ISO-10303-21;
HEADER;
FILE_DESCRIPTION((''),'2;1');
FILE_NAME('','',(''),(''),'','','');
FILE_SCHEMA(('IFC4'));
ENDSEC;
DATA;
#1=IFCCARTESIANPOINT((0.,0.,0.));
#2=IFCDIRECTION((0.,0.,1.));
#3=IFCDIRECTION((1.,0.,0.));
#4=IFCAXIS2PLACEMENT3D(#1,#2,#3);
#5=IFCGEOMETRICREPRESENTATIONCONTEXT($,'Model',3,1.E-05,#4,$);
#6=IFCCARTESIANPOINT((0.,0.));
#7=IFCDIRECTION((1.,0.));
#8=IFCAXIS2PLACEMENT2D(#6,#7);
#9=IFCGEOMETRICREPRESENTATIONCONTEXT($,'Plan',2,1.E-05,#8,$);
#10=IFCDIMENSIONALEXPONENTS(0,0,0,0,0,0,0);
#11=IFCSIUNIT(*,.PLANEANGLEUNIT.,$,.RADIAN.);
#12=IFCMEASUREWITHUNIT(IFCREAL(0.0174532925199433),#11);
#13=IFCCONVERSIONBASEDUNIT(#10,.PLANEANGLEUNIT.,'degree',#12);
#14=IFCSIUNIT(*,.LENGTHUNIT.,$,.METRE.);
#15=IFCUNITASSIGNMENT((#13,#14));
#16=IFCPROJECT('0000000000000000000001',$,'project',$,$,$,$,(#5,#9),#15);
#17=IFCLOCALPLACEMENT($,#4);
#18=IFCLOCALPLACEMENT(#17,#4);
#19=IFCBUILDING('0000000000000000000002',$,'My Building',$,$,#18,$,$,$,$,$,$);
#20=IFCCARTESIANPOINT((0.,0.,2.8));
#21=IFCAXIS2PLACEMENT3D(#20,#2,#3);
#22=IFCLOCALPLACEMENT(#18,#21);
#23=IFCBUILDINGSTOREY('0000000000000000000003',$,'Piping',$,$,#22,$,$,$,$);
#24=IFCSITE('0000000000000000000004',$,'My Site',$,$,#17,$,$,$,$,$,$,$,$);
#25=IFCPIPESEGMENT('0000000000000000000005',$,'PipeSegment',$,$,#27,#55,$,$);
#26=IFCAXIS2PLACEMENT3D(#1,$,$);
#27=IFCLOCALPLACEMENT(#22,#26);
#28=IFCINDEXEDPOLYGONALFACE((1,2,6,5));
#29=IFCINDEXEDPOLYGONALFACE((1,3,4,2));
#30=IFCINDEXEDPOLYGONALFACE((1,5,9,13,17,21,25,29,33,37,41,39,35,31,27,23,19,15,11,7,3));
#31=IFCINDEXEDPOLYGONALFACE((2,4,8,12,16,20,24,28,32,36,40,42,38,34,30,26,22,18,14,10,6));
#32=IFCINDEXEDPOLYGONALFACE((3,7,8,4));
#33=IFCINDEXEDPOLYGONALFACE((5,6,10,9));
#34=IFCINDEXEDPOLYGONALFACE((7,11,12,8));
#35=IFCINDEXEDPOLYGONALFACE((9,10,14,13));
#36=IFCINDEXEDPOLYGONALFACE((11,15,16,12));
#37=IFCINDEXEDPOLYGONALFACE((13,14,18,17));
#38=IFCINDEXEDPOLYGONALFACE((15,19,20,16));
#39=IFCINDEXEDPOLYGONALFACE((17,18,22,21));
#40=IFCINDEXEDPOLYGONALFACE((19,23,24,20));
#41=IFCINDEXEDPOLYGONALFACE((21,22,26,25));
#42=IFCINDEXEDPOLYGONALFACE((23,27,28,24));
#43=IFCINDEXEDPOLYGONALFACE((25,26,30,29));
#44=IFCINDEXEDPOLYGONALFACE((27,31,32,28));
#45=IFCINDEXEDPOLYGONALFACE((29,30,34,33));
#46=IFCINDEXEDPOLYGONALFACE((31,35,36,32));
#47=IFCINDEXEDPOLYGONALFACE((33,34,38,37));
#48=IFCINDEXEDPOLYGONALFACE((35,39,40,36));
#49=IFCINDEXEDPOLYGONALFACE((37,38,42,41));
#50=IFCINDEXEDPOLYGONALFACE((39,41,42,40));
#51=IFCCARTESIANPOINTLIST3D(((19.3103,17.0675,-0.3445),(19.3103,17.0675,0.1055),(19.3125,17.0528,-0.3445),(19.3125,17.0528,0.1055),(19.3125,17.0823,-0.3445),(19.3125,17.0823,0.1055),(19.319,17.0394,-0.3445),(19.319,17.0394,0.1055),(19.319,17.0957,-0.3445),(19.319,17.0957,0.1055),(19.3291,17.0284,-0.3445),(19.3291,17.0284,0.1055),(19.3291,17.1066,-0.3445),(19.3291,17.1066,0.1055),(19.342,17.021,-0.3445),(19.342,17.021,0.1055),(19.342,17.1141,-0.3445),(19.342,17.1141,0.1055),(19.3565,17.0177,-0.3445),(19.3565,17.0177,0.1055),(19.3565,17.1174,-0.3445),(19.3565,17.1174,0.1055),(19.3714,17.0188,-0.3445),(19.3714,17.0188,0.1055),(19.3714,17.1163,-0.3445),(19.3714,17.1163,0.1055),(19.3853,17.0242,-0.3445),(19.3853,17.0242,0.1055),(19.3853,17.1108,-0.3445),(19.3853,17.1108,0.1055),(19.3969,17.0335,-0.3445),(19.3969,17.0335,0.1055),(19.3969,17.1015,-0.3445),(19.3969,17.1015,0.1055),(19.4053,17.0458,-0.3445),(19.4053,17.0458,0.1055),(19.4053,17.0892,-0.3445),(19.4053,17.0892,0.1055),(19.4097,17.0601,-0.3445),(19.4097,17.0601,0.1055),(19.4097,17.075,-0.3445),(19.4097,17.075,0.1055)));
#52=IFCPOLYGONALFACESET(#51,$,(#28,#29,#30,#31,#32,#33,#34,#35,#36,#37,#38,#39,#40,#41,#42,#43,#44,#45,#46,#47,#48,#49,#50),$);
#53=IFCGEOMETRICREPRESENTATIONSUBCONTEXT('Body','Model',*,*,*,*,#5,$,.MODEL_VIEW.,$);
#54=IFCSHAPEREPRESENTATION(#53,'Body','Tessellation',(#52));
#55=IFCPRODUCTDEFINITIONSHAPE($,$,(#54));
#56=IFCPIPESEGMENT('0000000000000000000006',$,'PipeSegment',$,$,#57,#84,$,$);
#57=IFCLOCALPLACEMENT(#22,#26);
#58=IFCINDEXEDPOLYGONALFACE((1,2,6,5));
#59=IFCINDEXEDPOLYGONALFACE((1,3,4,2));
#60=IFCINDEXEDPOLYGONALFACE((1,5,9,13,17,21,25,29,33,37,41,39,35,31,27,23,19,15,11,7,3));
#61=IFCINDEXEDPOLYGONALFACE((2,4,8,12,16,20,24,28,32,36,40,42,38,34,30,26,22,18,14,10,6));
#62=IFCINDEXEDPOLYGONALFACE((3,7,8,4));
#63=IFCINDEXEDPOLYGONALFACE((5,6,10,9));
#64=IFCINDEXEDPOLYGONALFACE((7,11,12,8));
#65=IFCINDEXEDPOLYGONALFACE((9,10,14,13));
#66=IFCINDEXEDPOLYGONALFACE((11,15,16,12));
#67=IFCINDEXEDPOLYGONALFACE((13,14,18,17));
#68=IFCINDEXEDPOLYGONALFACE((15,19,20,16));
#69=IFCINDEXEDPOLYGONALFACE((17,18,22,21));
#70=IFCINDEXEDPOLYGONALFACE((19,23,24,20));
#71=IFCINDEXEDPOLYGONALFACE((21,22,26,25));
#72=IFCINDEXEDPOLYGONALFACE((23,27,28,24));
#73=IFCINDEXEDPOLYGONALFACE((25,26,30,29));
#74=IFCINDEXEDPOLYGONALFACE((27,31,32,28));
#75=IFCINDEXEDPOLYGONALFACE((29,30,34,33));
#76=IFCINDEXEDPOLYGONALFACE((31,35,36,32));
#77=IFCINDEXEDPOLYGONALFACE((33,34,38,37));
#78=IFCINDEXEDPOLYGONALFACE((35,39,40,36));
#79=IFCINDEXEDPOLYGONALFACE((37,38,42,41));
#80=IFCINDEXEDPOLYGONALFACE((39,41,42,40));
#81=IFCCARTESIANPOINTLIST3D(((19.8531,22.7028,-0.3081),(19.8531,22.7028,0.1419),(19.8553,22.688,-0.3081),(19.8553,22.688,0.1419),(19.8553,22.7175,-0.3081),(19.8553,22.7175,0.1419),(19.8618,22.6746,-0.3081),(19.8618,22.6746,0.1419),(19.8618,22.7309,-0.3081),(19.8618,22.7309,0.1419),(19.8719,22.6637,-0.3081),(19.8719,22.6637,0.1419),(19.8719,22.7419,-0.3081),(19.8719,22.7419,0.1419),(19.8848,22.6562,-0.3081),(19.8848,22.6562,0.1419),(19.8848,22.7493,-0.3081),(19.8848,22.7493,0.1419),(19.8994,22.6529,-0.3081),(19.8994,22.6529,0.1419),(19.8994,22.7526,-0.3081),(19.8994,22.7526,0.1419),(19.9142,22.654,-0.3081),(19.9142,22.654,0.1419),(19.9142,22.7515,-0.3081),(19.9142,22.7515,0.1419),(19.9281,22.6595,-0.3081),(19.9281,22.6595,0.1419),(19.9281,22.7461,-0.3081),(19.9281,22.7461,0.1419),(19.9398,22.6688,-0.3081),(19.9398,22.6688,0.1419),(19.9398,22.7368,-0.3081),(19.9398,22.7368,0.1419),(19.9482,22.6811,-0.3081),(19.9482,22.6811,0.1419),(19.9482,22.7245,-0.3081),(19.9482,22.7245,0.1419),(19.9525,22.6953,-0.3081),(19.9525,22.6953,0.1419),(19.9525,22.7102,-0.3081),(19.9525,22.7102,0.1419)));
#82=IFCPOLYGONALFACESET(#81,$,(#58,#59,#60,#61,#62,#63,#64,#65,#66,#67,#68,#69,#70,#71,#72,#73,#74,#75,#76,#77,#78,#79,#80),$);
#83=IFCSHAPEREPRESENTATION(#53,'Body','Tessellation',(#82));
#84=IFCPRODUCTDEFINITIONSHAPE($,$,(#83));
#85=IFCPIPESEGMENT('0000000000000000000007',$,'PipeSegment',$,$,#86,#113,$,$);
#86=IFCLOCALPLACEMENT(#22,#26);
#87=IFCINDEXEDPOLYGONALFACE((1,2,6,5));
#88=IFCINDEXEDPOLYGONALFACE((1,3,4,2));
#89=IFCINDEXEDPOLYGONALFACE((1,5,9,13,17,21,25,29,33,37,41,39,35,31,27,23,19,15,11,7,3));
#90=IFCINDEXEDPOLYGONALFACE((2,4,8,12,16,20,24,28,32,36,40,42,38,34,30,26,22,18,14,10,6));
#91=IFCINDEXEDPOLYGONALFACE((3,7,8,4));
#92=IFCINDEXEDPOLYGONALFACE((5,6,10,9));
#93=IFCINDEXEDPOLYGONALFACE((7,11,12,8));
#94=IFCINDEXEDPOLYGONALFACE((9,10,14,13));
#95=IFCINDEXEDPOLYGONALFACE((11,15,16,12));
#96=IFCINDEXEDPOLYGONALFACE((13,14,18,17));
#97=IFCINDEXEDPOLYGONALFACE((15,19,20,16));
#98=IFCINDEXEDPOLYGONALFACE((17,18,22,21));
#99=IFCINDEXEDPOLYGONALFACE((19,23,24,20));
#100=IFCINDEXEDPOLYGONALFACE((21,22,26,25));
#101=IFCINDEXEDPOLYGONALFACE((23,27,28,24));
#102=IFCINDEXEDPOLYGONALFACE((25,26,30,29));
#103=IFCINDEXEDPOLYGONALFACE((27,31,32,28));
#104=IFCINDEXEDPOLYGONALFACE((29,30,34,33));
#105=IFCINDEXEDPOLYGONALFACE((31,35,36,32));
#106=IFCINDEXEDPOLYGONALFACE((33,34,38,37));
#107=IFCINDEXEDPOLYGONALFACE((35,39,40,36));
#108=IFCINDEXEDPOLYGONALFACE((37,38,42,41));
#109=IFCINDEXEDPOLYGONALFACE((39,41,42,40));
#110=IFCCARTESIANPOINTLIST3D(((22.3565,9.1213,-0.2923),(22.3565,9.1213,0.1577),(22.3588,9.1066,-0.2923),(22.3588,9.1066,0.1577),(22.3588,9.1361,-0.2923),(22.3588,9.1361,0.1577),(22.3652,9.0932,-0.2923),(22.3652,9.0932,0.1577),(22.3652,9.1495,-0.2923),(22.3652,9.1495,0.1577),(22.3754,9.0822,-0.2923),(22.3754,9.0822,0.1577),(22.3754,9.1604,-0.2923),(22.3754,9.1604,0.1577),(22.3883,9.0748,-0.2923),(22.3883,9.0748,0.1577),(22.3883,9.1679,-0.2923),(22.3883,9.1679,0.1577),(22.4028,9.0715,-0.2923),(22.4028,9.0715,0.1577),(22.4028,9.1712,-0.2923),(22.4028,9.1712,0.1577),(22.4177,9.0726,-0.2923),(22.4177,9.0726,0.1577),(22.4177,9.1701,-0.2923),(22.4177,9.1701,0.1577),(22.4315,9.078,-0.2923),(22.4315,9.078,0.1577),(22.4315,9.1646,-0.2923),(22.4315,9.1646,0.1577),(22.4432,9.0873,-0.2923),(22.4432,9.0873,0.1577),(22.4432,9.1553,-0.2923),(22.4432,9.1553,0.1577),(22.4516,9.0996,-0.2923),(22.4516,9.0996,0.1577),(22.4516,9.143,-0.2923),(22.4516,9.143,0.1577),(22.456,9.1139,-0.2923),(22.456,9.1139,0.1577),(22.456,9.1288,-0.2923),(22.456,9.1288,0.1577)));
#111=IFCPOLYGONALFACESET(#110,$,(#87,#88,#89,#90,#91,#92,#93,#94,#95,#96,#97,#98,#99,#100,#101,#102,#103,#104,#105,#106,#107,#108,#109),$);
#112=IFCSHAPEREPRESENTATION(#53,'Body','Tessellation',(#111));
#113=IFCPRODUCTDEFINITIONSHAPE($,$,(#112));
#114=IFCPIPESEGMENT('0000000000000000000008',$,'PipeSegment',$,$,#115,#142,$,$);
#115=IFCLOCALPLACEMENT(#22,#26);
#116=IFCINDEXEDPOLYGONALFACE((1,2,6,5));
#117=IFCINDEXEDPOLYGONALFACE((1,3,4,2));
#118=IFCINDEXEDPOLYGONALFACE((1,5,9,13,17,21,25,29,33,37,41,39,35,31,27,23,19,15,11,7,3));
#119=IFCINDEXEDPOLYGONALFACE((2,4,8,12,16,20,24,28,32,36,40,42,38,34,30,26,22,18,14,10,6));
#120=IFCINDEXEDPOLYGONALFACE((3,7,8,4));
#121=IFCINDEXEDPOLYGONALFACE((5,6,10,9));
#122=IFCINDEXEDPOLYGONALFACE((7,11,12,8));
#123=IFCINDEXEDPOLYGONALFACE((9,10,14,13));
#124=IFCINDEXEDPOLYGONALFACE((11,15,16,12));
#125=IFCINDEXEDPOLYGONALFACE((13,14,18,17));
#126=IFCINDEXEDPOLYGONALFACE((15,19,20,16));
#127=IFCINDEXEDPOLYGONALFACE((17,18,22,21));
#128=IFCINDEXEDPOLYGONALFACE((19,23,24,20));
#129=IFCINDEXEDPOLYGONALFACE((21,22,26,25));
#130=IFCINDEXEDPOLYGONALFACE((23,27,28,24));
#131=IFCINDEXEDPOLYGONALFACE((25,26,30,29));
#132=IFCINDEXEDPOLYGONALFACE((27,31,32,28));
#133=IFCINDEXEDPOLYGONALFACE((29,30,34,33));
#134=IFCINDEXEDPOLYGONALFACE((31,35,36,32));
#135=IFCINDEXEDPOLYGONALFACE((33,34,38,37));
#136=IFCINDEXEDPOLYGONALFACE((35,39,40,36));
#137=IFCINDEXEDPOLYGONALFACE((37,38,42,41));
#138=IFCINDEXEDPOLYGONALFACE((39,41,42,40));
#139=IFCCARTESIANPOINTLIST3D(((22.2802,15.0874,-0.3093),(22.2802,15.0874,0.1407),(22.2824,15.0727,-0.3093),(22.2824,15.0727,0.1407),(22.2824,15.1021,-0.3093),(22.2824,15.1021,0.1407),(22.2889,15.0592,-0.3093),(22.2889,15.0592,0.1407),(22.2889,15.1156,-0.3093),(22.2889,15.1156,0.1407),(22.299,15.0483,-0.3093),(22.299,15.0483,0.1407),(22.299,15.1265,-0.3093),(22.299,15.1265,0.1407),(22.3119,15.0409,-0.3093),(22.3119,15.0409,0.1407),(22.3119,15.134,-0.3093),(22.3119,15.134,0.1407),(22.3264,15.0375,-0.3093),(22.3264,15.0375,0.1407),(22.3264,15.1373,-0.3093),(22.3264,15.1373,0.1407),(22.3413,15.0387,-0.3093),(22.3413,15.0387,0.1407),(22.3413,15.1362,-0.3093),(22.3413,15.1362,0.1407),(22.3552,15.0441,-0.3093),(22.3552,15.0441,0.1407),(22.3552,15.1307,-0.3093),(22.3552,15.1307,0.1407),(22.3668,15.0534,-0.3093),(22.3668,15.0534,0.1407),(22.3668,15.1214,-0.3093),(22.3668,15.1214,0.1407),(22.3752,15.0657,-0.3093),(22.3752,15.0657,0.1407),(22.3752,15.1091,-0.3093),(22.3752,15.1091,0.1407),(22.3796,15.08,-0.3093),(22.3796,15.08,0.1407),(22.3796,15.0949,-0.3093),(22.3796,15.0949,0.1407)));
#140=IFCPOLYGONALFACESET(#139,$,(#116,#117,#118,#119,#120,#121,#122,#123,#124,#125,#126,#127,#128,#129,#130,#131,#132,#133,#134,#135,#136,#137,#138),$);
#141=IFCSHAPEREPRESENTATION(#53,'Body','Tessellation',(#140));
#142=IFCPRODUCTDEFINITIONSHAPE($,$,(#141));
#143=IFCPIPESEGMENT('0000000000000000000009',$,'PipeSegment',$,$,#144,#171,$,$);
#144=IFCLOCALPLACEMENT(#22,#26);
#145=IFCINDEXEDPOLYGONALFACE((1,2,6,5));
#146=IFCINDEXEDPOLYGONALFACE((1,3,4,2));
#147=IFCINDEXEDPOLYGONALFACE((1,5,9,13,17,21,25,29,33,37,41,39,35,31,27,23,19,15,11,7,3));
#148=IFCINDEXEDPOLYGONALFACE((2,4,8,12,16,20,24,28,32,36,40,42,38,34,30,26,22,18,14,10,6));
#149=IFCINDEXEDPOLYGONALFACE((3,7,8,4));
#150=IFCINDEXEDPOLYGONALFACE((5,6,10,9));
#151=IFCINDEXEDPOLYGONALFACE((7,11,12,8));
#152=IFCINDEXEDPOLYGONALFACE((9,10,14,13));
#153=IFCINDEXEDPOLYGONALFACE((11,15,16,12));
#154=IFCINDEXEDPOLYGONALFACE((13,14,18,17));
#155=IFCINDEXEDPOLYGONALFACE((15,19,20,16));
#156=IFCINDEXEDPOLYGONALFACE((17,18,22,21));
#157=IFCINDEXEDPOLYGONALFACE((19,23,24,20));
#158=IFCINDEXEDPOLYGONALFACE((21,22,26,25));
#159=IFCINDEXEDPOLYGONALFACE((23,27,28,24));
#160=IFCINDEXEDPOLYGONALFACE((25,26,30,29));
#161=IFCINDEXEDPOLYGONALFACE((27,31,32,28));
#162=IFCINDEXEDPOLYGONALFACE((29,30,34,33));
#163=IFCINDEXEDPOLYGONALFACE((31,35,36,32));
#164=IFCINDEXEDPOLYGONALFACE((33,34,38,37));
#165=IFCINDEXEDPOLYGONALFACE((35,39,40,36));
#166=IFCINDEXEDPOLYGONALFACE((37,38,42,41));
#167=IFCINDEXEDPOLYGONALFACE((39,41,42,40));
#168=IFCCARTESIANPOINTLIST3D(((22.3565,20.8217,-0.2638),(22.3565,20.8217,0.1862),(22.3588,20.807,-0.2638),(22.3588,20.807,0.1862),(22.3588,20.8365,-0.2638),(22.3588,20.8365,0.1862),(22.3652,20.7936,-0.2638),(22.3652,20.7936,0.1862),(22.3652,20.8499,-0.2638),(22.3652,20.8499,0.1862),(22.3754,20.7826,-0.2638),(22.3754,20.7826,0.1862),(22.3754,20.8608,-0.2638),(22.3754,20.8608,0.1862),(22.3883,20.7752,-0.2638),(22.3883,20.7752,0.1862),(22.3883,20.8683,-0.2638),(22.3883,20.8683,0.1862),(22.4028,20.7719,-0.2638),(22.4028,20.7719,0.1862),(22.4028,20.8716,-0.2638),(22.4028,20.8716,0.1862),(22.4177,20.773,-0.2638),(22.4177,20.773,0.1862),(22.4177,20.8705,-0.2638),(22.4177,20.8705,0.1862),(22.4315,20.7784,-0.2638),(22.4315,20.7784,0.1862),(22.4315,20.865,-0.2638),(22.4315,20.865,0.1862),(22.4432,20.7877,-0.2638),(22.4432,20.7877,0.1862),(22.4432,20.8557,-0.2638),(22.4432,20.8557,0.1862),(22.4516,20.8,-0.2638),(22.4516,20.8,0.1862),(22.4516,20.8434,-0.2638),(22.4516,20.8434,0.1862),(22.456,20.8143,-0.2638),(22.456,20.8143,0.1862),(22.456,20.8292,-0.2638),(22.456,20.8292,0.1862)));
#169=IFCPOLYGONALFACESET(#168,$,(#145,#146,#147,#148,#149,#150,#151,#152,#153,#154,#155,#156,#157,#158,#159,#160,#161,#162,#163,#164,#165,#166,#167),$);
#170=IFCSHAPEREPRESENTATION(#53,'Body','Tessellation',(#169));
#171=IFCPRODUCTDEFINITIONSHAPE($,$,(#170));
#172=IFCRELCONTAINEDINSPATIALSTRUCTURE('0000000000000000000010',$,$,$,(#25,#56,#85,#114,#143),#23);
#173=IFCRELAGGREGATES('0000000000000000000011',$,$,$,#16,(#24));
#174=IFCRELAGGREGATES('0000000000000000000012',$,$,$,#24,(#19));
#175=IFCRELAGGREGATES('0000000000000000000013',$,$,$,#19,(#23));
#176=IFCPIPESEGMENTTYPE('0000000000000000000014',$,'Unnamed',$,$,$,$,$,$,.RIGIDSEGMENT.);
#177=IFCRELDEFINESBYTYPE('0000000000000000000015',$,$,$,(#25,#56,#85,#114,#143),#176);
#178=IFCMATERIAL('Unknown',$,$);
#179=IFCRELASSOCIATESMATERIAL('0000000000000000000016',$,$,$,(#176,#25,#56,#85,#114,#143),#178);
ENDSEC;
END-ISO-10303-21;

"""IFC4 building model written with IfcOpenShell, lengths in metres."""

from ifc_helpers import new_model, entity, si_unit, converted_unit, frame, origin_with_axes, origin_2d_with_axis, place, context, subcontext, project, spatial, circle, extrude, material, material_profile, profile_set, profile_usage, type_object, element, save


model = new_model("IFC4")

# Units and contexts
model_context = context("Model", 3, precision=1e-05, world=origin_with_axes())
plan_context = context("Plan", 2, precision=1e-05, world=origin_2d_with_axis())
body_context = subcontext(model_context, "Body", "Model", "MODEL_VIEW")
ifc_project = project(units=[converted_unit("PLANEANGLEUNIT", "degree", entity("IfcReal", 0.0174532925199433), si_unit("PLANEANGLEUNIT", "RADIAN"), dimensions=[0, 0, 0, 0, 0, 0, 0]), si_unit("LENGTHUNIT", "METRE")], contexts=[model_context, plan_context])

# Site, building, storey
site_placement = place(None, origin_with_axes())
site = spatial("IfcSite", under=ifc_project, at=site_placement, Name="My Site")
building_placement = place(site_placement, origin_with_axes())
building = spatial("IfcBuilding", under=site, at=building_placement, Name="My Building")
storey_placement = place(building_placement, frame((0.0, 0.0, 2.8), z_axis=(0.0, 0.0, 1.0), x_axis=(1.0, 0.0, 0.0)))
storey = spatial("IfcBuildingStorey", under=building, at=storey_placement, Name="Piping")

# Pipe segments
ifc_material = material(Name="Unknown")
ifc_material_profile_1 = material_profile(ifc_material, circle(Radius=0.05))
ifc_profile_set_1 = profile_set([ifc_material_profile_1])
pipe_segment_type = type_object("IfcPipeSegmentType", Name="Unnamed", PredefinedType="RIGIDSEGMENT", material=ifc_profile_set_1)
ifc_profile_usage_1 = profile_usage(ifc_profile_set_1, cardinal=5)
pipe_segment_1_placement = place(storey_placement, frame((19.3603, 17.0675, 0.1055), z_axis=(0.0, 0.0, -1.0), x_axis=(-1.0, 0.0, 0.0)))
element("IfcPipeSegment", 1, at=pipe_segment_1_placement, inside=storey, type_object=pipe_segment_type, material=ifc_profile_usage_1, Name="PipeSegment", context=body_context, shape_type="SweptSolid", body=[
    extrude(circle(Radius=0.05), origin_with_axes(), (0.0, 0.0, 1.0), 0.45),
])
ifc_profile_usage_2 = profile_usage(ifc_profile_set_1, cardinal=5)
pipe_segment_2_placement = place(storey_placement, frame((19.9031, 22.7028, 0.1419), z_axis=(0.0, 0.0, -1.0), x_axis=(-1.0, 0.0, 0.0)))
element("IfcPipeSegment", 2, at=pipe_segment_2_placement, inside=storey, type_object=pipe_segment_type, material=ifc_profile_usage_2, Name="PipeSegment", context=body_context, shape_type="SweptSolid", body=[
    extrude(circle(Radius=0.05), origin_with_axes(), (0.0, 0.0, 1.0), 0.45),
])
ifc_profile_usage_3 = profile_usage(ifc_profile_set_1, cardinal=5)
pipe_segment_3_placement = place(storey_placement, frame((22.4065, 9.1213, 0.1577), z_axis=(0.0, 0.0, -1.0), x_axis=(-1.0, 0.0, 0.0)))
element("IfcPipeSegment", 3, at=pipe_segment_3_placement, inside=storey, type_object=pipe_segment_type, material=ifc_profile_usage_3, Name="PipeSegment", context=body_context, shape_type="SweptSolid", body=[
    extrude(circle(Radius=0.05), origin_with_axes(), (0.0, 0.0, 1.0), 0.45),
])
ifc_profile_usage_4 = profile_usage(ifc_profile_set_1, cardinal=5)
pipe_segment_4_placement = place(storey_placement, frame((22.3302, 15.0874, 0.1407), z_axis=(0.0, 0.0, -1.0), x_axis=(-1.0, 0.0, 0.0)))
element("IfcPipeSegment", 4, at=pipe_segment_4_placement, inside=storey, type_object=pipe_segment_type, material=ifc_profile_usage_4, Name="PipeSegment", context=body_context, shape_type="SweptSolid", body=[
    extrude(circle(Radius=0.05), origin_with_axes(), (0.0, 0.0, 1.0), 0.45),
])
ifc_profile_usage_5 = profile_usage(ifc_profile_set_1, cardinal=5)
pipe_segment_5_placement = place(storey_placement, frame((22.4065, 20.8217, 0.1862), z_axis=(0.0, 0.0, -1.0), x_axis=(-1.0, 0.0, 0.0)))
element("IfcPipeSegment", 5, at=pipe_segment_5_placement, inside=storey, type_object=pipe_segment_type, material=ifc_profile_usage_5, Name="PipeSegment", context=body_context, shape_type="SweptSolid", body=[
    extrude(circle(Radius=0.05), origin_with_axes(), (0.0, 0.0, 1.0), 0.45),
])

save(model, "model.ifc")
